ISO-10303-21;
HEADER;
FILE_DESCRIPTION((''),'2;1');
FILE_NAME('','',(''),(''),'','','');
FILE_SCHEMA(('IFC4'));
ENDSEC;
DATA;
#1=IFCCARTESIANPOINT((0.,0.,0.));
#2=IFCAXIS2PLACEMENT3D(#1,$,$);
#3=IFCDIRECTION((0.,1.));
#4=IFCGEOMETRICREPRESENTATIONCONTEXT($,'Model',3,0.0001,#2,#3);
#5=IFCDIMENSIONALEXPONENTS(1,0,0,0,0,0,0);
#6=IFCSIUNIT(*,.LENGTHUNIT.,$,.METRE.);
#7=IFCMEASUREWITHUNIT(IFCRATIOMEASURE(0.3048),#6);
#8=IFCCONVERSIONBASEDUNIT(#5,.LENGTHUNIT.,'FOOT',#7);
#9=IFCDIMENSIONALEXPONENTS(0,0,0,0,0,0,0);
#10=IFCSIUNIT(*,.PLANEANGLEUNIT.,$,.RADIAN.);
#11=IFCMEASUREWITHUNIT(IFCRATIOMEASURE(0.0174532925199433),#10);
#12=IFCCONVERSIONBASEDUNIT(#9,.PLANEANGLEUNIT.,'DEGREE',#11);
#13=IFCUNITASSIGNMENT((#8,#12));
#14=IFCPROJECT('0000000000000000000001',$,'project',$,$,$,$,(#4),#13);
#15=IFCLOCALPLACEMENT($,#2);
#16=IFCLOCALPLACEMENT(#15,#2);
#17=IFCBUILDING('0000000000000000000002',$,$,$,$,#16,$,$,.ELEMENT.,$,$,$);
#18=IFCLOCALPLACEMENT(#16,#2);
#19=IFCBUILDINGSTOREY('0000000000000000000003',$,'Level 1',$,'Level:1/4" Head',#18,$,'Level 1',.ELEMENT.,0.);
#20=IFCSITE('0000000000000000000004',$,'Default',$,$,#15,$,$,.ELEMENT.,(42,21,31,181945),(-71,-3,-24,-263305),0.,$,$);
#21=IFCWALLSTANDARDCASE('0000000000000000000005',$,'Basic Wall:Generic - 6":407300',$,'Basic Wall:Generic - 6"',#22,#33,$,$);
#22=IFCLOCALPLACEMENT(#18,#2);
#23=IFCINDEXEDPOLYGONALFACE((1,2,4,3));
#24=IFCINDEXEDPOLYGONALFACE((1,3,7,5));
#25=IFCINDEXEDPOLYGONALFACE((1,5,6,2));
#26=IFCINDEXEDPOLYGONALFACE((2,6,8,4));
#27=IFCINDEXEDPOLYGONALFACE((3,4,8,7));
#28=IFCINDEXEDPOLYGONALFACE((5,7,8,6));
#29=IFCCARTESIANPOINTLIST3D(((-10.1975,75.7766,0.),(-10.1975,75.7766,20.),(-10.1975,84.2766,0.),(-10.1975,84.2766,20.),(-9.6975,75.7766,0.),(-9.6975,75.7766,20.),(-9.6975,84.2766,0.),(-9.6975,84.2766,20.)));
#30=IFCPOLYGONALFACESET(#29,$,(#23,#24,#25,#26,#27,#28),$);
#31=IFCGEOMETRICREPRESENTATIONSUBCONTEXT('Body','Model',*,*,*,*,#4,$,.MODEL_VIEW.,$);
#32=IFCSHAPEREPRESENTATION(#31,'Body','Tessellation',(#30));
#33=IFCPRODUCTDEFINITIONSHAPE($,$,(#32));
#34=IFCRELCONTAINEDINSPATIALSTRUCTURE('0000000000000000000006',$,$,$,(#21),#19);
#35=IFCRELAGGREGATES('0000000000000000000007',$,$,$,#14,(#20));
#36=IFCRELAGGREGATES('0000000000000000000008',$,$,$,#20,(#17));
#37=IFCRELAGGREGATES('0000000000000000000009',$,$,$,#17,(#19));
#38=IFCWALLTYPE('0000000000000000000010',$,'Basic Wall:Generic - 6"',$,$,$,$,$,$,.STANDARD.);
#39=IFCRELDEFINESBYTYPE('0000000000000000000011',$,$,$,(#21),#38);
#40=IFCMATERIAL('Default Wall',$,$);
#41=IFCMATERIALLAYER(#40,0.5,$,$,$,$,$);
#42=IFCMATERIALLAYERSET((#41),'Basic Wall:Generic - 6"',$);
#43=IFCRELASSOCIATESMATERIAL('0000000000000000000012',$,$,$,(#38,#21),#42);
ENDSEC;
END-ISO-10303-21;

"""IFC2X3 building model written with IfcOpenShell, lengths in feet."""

from ifc_helpers import new_model, entity, si_unit, converted_unit, direction, frame, frame_2d, origin, place, context, subcontext, project, spatial, rectangle, extrude, material, layer, layer_set, layer_usage, type_object, element, save


model = new_model("IFC2X3")

# Units and contexts
model_context = context("Model", 3, precision=0.0001, world=origin(), true_north=direction((0.0, 1.0)))
body_context = subcontext(model_context, "Body", "Model", "MODEL_VIEW")
ifc_project = project(units=[converted_unit("LENGTHUNIT", "FOOT", entity("IfcRatioMeasure", 0.3048), si_unit("LENGTHUNIT", "METRE"), dimensions=[1, 0, 0, 0, 0, 0, 0]), converted_unit("PLANEANGLEUNIT", "DEGREE", entity("IfcRatioMeasure", 0.0174532925199433), si_unit("PLANEANGLEUNIT", "RADIAN"), dimensions=[0, 0, 0, 0, 0, 0, 0])], contexts=[model_context])

# Site, building, storey
site_placement = place(None, origin())
site = spatial("IfcSite", under=ifc_project, at=site_placement, Name="Default", CompositionType="ELEMENT", RefLatitude=(42, 21, 31, 181945), RefLongitude=(-71, -3, -24, -263305), RefElevation=0.0)
building_placement = place(site_placement, origin())
building = spatial("IfcBuilding", under=site, at=building_placement, CompositionType="ELEMENT")
storey_placement = place(building_placement, origin())
storey = spatial("IfcBuildingStorey", under=building, at=storey_placement, Name="Level 1", ObjectType="Level:1/4\" Head", LongName="Level 1", CompositionType="ELEMENT", Elevation=0.0)

# Shared definitions
ifc_material = material(Name="Default Wall")
ifc_layer = layer(ifc_material, 0.5)
ifc_layer_set = layer_set([ifc_layer], Name="Basic Wall:Generic - 6\"")
wall_type = type_object("IfcWallType", Name="Basic Wall:Generic - 6\"", PredefinedType="STANDARD", material=ifc_layer_set)

# Wall
ifc_layer_usage_1 = layer_usage(ifc_layer_set, "AXIS2", "NEGATIVE", 0.25)
wall_1_placement = place(storey_placement, frame((-9.9475, 84.2766, 0.0), z_axis=(0.0, 0.0, 1.0), x_axis=(0.0, -1.0, 0.0)))
element("IfcWallStandardCase", 1, at=wall_1_placement, inside=storey, type_object=wall_type, material=ifc_layer_usage_1, Name="Basic Wall:Generic - 6\":407300", ObjectType="Basic Wall:Generic - 6\"", context=body_context, shape_type="SweptSolid", body=[
    extrude(rectangle(XDim=8.5, YDim=0.5, at=frame_2d((4.25, 0.0), x_axis=(-1.0, 0.0))), origin(), (0.0, 0.0, 1.0), 20.0),
])

save(model, "model.ifc")
